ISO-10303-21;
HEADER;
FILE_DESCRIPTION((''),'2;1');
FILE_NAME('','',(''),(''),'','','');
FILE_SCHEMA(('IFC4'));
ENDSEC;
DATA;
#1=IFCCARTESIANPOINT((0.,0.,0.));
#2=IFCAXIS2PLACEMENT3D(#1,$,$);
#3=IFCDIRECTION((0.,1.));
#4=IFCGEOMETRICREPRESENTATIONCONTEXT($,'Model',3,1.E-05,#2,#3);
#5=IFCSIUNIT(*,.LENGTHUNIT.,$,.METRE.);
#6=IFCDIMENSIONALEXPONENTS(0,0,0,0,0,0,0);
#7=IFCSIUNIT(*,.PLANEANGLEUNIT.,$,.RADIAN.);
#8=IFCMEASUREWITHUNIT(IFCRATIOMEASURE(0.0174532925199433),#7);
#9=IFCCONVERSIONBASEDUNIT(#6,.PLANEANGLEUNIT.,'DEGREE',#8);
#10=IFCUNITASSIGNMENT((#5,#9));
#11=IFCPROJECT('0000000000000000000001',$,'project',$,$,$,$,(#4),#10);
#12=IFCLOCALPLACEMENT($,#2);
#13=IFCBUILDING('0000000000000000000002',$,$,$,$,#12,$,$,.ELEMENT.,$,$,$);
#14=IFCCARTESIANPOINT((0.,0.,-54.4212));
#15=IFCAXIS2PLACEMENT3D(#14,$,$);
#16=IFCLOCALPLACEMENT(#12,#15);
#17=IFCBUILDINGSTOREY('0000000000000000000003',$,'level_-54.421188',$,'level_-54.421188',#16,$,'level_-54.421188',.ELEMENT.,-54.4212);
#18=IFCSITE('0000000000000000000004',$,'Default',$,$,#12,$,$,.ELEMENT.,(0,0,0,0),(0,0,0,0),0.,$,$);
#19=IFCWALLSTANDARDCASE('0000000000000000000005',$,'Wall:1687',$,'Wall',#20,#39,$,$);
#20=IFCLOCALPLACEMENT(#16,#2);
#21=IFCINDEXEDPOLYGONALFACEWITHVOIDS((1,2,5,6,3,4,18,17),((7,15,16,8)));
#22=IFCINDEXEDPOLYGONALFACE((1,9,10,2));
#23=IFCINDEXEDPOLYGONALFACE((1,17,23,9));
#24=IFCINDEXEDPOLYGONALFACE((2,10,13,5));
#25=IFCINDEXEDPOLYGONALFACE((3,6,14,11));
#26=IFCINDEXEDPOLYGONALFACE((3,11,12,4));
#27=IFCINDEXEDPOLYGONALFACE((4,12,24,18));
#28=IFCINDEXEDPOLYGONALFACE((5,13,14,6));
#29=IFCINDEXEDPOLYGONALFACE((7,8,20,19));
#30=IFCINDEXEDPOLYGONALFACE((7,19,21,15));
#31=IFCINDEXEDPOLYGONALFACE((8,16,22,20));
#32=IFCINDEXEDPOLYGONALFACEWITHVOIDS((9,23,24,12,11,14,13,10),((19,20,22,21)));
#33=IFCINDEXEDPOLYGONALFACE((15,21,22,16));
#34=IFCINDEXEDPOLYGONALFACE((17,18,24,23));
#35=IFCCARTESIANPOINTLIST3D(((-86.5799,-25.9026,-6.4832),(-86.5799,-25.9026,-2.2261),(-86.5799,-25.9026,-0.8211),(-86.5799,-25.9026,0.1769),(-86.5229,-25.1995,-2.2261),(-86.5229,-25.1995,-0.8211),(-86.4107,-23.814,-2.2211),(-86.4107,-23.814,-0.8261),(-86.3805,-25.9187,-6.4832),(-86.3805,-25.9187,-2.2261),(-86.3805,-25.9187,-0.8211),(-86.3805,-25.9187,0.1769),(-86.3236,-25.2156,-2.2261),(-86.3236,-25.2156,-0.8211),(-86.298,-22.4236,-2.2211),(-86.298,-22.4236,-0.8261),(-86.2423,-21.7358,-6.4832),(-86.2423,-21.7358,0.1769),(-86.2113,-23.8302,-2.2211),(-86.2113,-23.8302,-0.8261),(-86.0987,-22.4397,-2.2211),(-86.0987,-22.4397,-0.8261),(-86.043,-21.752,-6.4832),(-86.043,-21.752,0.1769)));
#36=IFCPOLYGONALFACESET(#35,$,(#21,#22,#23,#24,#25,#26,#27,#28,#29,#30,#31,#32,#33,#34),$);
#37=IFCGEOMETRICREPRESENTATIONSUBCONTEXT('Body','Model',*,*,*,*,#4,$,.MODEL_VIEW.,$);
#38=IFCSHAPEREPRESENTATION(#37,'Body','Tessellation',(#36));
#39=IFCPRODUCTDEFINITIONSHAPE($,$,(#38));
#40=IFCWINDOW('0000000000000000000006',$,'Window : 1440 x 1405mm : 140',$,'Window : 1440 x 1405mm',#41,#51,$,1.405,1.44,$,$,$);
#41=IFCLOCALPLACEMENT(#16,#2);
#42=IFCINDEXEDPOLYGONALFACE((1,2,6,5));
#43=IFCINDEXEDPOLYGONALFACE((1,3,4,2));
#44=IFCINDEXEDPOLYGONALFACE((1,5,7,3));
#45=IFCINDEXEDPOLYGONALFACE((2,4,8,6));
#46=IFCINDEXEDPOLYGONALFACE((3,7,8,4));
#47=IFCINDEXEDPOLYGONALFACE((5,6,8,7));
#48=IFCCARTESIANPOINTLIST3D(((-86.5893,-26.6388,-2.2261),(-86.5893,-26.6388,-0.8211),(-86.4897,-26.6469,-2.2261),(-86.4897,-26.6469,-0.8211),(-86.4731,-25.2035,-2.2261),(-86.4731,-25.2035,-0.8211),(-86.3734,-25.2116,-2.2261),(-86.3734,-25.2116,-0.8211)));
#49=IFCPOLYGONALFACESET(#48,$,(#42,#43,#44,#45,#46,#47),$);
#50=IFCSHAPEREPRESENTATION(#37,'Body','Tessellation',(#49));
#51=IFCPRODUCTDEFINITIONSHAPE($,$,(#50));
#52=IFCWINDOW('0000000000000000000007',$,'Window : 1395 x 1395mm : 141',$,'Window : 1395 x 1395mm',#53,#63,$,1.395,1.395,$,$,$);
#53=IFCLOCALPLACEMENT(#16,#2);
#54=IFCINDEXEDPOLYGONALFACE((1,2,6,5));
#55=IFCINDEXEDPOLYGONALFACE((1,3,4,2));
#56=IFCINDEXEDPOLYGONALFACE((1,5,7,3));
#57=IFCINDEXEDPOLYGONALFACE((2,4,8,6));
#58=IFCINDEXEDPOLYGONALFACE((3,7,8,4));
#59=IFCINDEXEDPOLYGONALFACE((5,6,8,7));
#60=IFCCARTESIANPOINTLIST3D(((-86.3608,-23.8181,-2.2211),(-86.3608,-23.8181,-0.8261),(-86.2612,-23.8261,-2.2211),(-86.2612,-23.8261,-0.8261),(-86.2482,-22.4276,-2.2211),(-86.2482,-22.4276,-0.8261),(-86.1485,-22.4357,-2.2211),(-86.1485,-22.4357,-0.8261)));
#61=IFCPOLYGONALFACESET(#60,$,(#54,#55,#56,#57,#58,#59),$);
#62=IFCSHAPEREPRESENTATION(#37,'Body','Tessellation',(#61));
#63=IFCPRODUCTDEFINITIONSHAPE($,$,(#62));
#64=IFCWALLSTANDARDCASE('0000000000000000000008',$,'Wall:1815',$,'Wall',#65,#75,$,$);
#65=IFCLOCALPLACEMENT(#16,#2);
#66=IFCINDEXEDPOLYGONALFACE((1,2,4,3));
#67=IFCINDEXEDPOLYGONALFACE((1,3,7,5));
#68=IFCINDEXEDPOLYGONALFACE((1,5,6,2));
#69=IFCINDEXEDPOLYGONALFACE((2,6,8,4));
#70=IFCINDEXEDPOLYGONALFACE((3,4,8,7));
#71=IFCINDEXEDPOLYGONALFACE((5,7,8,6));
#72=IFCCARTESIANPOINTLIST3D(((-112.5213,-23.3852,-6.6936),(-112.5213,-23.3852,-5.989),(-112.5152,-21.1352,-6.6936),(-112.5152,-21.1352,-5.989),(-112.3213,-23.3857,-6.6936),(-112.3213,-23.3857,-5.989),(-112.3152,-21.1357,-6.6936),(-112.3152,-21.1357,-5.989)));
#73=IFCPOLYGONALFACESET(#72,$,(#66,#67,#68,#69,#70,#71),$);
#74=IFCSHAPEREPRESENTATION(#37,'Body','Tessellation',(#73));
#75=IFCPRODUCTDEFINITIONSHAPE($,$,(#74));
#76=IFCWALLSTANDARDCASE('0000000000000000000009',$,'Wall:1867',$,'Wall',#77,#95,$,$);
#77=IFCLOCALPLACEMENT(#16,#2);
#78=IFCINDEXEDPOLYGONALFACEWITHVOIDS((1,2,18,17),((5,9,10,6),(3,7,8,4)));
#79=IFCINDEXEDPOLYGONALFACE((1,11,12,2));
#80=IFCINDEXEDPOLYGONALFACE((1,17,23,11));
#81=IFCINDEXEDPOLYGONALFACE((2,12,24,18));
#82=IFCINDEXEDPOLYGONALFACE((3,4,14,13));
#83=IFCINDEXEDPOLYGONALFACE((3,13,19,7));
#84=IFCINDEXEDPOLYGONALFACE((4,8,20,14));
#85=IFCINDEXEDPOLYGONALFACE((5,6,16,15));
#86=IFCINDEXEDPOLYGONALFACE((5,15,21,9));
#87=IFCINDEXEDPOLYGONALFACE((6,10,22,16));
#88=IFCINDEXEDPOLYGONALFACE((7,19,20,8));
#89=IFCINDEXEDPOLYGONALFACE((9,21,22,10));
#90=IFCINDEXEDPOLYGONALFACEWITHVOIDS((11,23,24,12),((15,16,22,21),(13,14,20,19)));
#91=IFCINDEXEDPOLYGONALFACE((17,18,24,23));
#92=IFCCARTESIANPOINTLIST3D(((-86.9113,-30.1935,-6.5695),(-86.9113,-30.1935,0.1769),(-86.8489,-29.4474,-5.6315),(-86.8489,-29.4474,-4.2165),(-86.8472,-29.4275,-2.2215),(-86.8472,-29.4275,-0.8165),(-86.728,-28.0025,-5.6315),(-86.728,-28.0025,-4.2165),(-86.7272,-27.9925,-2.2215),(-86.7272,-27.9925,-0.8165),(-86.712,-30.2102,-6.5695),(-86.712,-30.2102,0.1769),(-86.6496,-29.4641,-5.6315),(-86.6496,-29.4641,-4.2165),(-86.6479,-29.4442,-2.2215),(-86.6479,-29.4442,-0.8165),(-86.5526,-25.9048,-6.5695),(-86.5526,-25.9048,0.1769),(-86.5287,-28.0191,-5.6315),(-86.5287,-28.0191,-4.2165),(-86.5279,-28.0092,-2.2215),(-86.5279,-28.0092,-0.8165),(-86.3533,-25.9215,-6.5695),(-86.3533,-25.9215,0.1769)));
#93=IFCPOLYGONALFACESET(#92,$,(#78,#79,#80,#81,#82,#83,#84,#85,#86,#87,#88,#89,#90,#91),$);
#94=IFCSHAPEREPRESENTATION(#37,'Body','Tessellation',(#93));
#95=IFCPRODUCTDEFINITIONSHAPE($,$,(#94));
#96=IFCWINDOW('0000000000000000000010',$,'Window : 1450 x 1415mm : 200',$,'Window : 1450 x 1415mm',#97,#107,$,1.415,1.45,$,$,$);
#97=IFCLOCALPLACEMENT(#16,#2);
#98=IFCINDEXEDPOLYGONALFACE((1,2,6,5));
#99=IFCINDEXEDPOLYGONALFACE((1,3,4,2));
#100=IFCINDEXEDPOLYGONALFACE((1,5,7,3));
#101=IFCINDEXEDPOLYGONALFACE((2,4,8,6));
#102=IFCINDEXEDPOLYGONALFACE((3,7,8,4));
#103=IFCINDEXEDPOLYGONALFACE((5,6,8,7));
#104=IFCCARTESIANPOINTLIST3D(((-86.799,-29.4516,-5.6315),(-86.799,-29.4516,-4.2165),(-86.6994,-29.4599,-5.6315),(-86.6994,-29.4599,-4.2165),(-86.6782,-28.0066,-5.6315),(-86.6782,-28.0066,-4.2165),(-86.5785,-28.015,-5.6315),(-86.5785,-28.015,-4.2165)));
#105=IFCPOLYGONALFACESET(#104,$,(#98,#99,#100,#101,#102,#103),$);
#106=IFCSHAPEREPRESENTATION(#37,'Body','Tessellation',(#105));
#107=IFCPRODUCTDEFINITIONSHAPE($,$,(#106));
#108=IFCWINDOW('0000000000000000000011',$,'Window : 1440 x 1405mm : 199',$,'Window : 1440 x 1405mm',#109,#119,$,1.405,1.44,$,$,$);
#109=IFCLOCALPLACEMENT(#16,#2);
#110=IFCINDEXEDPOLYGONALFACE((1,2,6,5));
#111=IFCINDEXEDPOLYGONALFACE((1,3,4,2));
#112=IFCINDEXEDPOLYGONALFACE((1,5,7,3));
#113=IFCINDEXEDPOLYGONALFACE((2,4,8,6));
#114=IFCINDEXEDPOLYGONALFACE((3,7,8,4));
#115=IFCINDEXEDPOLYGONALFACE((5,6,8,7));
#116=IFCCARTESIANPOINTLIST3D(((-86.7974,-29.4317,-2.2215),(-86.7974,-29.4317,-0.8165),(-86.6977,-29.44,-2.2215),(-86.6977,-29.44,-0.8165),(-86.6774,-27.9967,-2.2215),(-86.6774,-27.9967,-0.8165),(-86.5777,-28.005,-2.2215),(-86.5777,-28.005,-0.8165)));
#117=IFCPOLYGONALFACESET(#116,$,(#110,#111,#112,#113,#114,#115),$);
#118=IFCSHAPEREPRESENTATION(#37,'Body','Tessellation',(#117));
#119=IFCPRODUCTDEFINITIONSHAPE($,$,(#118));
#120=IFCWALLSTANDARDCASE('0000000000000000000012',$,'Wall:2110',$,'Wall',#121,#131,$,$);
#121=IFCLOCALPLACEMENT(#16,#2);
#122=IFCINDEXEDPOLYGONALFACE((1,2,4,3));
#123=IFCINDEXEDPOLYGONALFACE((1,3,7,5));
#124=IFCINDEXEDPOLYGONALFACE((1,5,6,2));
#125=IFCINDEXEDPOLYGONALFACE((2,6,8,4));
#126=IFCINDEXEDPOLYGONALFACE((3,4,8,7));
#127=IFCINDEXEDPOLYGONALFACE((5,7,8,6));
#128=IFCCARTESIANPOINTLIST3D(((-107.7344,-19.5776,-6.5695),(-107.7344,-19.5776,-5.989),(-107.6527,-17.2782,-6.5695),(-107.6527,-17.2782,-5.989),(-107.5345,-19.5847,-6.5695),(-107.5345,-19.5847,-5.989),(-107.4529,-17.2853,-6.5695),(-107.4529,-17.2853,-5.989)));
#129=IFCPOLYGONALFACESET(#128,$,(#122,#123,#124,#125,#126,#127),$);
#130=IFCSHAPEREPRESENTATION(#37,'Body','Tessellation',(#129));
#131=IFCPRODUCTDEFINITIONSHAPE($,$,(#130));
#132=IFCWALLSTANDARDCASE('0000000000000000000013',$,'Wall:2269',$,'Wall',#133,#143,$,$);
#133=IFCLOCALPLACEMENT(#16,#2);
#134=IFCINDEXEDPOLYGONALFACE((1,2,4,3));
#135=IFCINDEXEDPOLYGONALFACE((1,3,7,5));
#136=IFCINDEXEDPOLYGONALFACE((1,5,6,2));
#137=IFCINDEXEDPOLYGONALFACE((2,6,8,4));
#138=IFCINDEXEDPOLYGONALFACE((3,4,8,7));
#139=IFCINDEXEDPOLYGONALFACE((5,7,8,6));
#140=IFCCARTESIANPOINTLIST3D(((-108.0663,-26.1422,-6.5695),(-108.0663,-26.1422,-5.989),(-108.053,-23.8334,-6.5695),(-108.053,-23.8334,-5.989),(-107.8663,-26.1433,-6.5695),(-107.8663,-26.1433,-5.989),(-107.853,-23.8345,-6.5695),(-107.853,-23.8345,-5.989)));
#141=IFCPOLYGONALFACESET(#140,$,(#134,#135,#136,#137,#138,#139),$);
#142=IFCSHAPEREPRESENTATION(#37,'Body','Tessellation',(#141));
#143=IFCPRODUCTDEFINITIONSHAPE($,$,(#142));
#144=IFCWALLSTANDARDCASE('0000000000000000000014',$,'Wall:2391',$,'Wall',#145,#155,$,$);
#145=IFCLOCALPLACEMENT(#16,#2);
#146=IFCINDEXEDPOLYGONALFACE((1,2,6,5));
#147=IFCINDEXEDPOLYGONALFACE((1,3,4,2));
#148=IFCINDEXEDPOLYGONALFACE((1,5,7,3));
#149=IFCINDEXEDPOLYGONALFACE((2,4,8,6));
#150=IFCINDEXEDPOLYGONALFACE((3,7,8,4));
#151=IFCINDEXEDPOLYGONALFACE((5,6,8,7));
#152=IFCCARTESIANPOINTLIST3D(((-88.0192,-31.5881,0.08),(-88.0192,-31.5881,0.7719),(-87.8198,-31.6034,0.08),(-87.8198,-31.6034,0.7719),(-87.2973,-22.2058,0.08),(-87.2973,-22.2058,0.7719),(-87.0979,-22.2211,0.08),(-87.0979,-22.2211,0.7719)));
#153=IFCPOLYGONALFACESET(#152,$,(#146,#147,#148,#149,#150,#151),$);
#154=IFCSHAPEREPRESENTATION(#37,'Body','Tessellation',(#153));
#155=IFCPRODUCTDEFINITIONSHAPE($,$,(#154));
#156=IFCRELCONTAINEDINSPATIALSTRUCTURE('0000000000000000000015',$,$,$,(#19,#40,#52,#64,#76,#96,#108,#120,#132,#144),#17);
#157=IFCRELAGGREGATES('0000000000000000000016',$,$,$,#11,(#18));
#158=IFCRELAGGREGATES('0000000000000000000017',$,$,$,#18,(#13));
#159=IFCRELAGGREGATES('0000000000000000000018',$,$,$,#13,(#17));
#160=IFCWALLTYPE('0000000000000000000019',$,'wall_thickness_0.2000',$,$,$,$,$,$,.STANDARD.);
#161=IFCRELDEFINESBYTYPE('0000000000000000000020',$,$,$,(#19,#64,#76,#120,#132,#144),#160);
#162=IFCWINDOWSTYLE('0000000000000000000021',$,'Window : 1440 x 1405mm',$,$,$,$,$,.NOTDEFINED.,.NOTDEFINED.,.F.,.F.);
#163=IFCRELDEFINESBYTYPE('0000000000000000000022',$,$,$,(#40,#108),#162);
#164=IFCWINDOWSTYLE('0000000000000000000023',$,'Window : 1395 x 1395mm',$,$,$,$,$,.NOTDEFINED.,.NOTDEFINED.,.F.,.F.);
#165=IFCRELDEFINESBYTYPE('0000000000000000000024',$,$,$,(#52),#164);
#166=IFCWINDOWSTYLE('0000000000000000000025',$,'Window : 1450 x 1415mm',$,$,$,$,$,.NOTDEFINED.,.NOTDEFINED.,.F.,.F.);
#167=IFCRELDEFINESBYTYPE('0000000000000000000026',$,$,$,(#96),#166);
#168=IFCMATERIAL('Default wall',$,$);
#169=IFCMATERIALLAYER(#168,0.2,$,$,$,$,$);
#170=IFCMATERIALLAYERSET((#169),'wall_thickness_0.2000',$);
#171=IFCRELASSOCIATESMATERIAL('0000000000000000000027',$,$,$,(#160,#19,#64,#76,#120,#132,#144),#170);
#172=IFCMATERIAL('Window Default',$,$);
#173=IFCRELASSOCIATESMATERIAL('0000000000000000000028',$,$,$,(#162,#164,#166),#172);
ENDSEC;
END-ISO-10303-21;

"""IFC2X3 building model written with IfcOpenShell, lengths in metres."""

from ifc_helpers import new_model, entity, si_unit, converted_unit, direction, frame, frame_2d, origin, origin_2d_with_axis, place, context, subcontext, project, spatial, polyline, rectangle, outline, extrude, source, transform, mapped, material, layer, layer_set, layer_usage, type_object, type_shapes, element, fill, save


model = new_model("IFC2X3")

# Units and contexts
model_context = context("Model", 3, precision=1e-05, world=origin(), true_north=direction((0.0, 1.0)))
body_context = subcontext(model_context, "Body", "Model", "MODEL_VIEW")
ifc_project = project(units=[si_unit("LENGTHUNIT", "METRE"), converted_unit("PLANEANGLEUNIT", "DEGREE", entity("IfcRatioMeasure", 0.0174532925199433), si_unit("PLANEANGLEUNIT", "RADIAN"), dimensions=[0, 0, 0, 0, 0, 0, 0])], contexts=[model_context])

# Site, building, storey
placement_1 = place(None, origin())
site = spatial("IfcSite", under=ifc_project, at=placement_1, Name="Default", CompositionType="ELEMENT", RefLatitude=(0, 0, 0, 0), RefLongitude=(0, 0, 0, 0), RefElevation=0.0)
building = spatial("IfcBuilding", under=site, at=placement_1, CompositionType="ELEMENT")
storey_placement = place(placement_1, frame((0.0, 0.0, -54.4212)))
storey = spatial("IfcBuildingStorey", under=building, at=storey_placement, Name="level_-54.421188", ObjectType="level_-54.421188", LongName="level_-54.421188", CompositionType="ELEMENT", Elevation=-54.4212)

# Shared definitions
ifc_material_1 = material(Name="Default wall")
ifc_layer = layer(ifc_material_1, 0.2)
ifc_layer_set = layer_set([ifc_layer], Name="wall_thickness_0.2000")
ifc_layer_usage = layer_usage(ifc_layer_set, "AXIS2", "POSITIVE", -0.1)
wall_type = type_object("IfcWallType", Name="wall_thickness_0.2000", PredefinedType="STANDARD", material=ifc_layer_set)
ifc_material_2 = material(Name="Window Default")

# Wall, openings, windows
placement_2 = place(placement_1, frame((0.0, 0.0, -60.9044)))
wall_1_placement = place(placement_2, frame((-86.1426, -21.7439, 0.0), z_axis=(0.0, 0.0, 1.0), x_axis=(-0.080745, -0.996735, 0.0)))
wall_1 = element("IfcWallStandardCase", 1, at=wall_1_placement, inside=storey, type_object=wall_type, material=ifc_layer_usage, Name="Wall:1687", ObjectType="Wall", context=body_context, shape_type="SweptSolid", body=[
    extrude(outline(polyline([(4.1804, -0.1), (4.1804, 0.1), (0.0, 0.1), (0.0, -0.1), (4.1804, -0.1)])), origin(), (0.0, 0.0, 1.0), 6.6601),
])
opening_1_placement = place(wall_1_placement, frame((3.475, -0.1, 4.2571)))
opening_1 = element("IfcOpeningElement", 2, at=opening_1_placement, cuts=wall_1, ObjectType="Opening", context=body_context, shape_type="SweptSolid", body=[
    extrude(rectangle(XDim=1.44, YDim=1.405, at=frame_2d((0.7025, 0.72), x_axis=(0.0, 1.0))), frame((0.0, 0.0, 0.0), z_axis=(0.0, 1.0, 0.0), x_axis=(0.0, 0.0, 1.0)), (0.0, 0.0, 1.0), 0.2),
])
opening_2_placement = place(wall_1_placement, frame((0.69, -0.1, 4.2621)))
opening_2 = element("IfcOpeningElement", 3, at=opening_2_placement, cuts=wall_1, ObjectType="Opening", context=body_context, shape_type="SweptSolid", body=[
    extrude(rectangle(XDim=1.395, YDim=1.395, at=frame_2d((0.6975, 0.6975), x_axis=(0.0, 1.0))), frame((0.0, 0.0, 0.0), z_axis=(0.0, 1.0, 0.0), x_axis=(0.0, 0.0, 1.0)), (0.0, 0.0, 1.0), 0.2),
])
window_style_1 = type_object("IfcWindowStyle", Name="Window : 1440 x 1405mm", ConstructionType="NOTDEFINED", OperationType="NOTDEFINED", ParameterTakesPrecedence=False, Sizeable=False, material=ifc_material_2)
shared_shape_1 = source(origin(), body_context, "Body", "SweptSolid", [
    extrude(rectangle(XDim=0.1, YDim=1.44, at=origin_2d_with_axis()), frame((0.72, 0.1, 0.0), z_axis=(0.0, 0.0, 1.0), x_axis=(0.0, 1.0, 0.0)), (0.0, 0.0, 1.0), 1.405),
])
type_shapes(window_style_1, [shared_shape_1])
window_1_placement = place(opening_1_placement, origin())
window_1 = element("IfcWindow", 4, at=window_1_placement, inside=storey, type_object=window_style_1, Name="Window : 1440 x 1405mm : 140", ObjectType="Window : 1440 x 1405mm", OverallHeight=1.405, OverallWidth=1.44, context=body_context, shape_type="MappedRepresentation", body=[
    mapped(shared_shape_1, transform((0.0, 0.0, 0.0), scale=1.0)),
])
fill(opening_1, window_1)
window_style_2 = type_object("IfcWindowStyle", Name="Window : 1395 x 1395mm", ConstructionType="NOTDEFINED", OperationType="NOTDEFINED", ParameterTakesPrecedence=False, Sizeable=False, material=ifc_material_2)
shared_shape_2 = source(origin(), body_context, "Body", "SweptSolid", [
    extrude(rectangle(XDim=0.1, YDim=1.395, at=origin_2d_with_axis()), frame((0.6975, 0.1, 0.0), z_axis=(0.0, 0.0, 1.0), x_axis=(0.0, 1.0, 0.0)), (0.0, 0.0, 1.0), 1.395),
])
type_shapes(window_style_2, [shared_shape_2])
window_2_placement = place(opening_2_placement, origin())
window_2 = element("IfcWindow", 5, at=window_2_placement, inside=storey, type_object=window_style_2, Name="Window : 1395 x 1395mm : 141", ObjectType="Window : 1395 x 1395mm", OverallHeight=1.395, OverallWidth=1.395, context=body_context, shape_type="MappedRepresentation", body=[
    mapped(shared_shape_2, transform((0.0, 0.0, 0.0), scale=1.0)),
])
fill(opening_2, window_2)

# Wall
placement_3 = place(placement_1, frame((0.0, 0.0, -61.1148)))
wall_2_placement = place(placement_3, frame((-112.4152, -21.1355, 0.0), z_axis=(0.0, 0.0, 1.0), x_axis=(-0.002692, -0.999996, 0.0)))
element("IfcWallStandardCase", 6, at=wall_2_placement, inside=storey, type_object=wall_type, material=ifc_layer_usage, Name="Wall:1815", ObjectType="Wall", context=body_context, shape_type="SweptSolid", body=[
    extrude(outline(polyline([(2.25, -0.1), (2.25, 0.1), (0.0, 0.1), (0.0, -0.1), (2.25, -0.1)])), origin(), (0.0, 0.0, 1.0), 0.7046),
])

# Wall, openings, windows
placement_4 = place(placement_1, frame((0.0, 0.0, -60.9907)))
wall_3_placement = place(placement_4, frame((-86.453, -25.9131, 0.0), z_axis=(0.0, 0.0, 1.0), x_axis=(-0.083335, -0.996522, 0.0)))
wall_3 = element("IfcWallStandardCase", 7, at=wall_3_placement, inside=storey, type_object=wall_type, material=ifc_layer_usage, Name="Wall:1867", ObjectType="Wall", context=body_context, shape_type="SweptSolid", body=[
    extrude(outline(polyline([(4.3037, -0.1), (4.3037, 0.1), (0.0, 0.1), (0.0, -0.1), (4.3037, -0.1)])), origin(), (0.0, 0.0, 1.0), 6.7464),
])
opening_3_placement = place(wall_3_placement, frame((2.095, -0.1, 4.3479)))
opening_3 = element("IfcOpeningElement", 8, at=opening_3_placement, cuts=wall_3, ObjectType="Opening", context=body_context, shape_type="SweptSolid", body=[
    extrude(rectangle(XDim=1.44, YDim=1.405, at=frame_2d((0.7025, 0.72), x_axis=(0.0, 1.0))), frame((0.0, 0.0, 0.0), z_axis=(0.0, 1.0, 0.0), x_axis=(0.0, 0.0, 1.0)), (0.0, 0.0, 1.0), 0.2),
])
opening_4_placement = place(wall_3_placement, frame((2.105, -0.1, 0.9379)))
opening_4 = element("IfcOpeningElement", 9, at=opening_4_placement, cuts=wall_3, ObjectType="Opening", context=body_context, shape_type="SweptSolid", body=[
    extrude(rectangle(XDim=1.45, YDim=1.415, at=frame_2d((0.7075, 0.725), x_axis=(0.0, 1.0))), frame((0.0, 0.0, 0.0), z_axis=(0.0, 1.0, 0.0), x_axis=(0.0, 0.0, 1.0)), (0.0, 0.0, 1.0), 0.2),
])
window_style_3 = type_object("IfcWindowStyle", Name="Window : 1450 x 1415mm", ConstructionType="NOTDEFINED", OperationType="NOTDEFINED", ParameterTakesPrecedence=False, Sizeable=False, material=ifc_material_2)
shared_shape_3 = source(origin(), body_context, "Body", "SweptSolid", [
    extrude(rectangle(XDim=0.1, YDim=1.45, at=origin_2d_with_axis()), frame((0.725, 0.1, 0.0), z_axis=(0.0, 0.0, 1.0), x_axis=(0.0, 1.0, 0.0)), (0.0, 0.0, 1.0), 1.415),
])
type_shapes(window_style_3, [shared_shape_3])
window_3_placement = place(opening_4_placement, origin())
window_3 = element("IfcWindow", 10, at=window_3_placement, inside=storey, type_object=window_style_3, Name="Window : 1450 x 1415mm : 200", ObjectType="Window : 1450 x 1415mm", OverallHeight=1.415, OverallWidth=1.45, context=body_context, shape_type="MappedRepresentation", body=[
    mapped(shared_shape_3, transform((0.0, 0.0, 0.0), scale=1.0)),
])
fill(opening_4, window_3)
window_4_placement = place(opening_3_placement, origin())
window_4 = element("IfcWindow", 11, at=window_4_placement, inside=storey, type_object=window_style_1, Name="Window : 1440 x 1405mm : 199", ObjectType="Window : 1440 x 1405mm", OverallHeight=1.405, OverallWidth=1.44, context=body_context, shape_type="MappedRepresentation", body=[
    mapped(shared_shape_1, transform((0.0, 0.0, 0.0), scale=1.0)),
])
fill(opening_3, window_4)

# Walls
placement_5 = place(placement_1, frame((0.0, 0.0, -60.9907)))
wall_4_placement = place(placement_5, frame((-107.6344, -19.5812, 0.0), z_axis=(0.0, 0.0, 1.0), x_axis=(0.035486, 0.99937, 0.0)))
element("IfcWallStandardCase", 12, at=wall_4_placement, inside=storey, type_object=wall_type, material=ifc_layer_usage, Name="Wall:2110", ObjectType="Wall", context=body_context, shape_type="SweptSolid", body=[
    extrude(outline(polyline([(2.3009, -0.1), (2.3009, 0.1), (0.0, 0.1), (0.0, -0.1), (2.3009, -0.1)])), origin(), (0.0, 0.0, 1.0), 0.5805),
])
placement_6 = place(placement_1, frame((0.0, 0.0, -60.9907)))
wall_5_placement = place(placement_6, frame((-107.9663, -26.1428, 0.0), z_axis=(0.0, 0.0, 1.0), x_axis=(0.005746, 0.999983, 0.0)))
element("IfcWallStandardCase", 13, at=wall_5_placement, inside=storey, type_object=wall_type, material=ifc_layer_usage, Name="Wall:2269", ObjectType="Wall", context=body_context, shape_type="SweptSolid", body=[
    extrude(outline(polyline([(2.3089, -0.1), (2.3089, 0.1), (0.0, 0.1), (0.0, -0.1), (2.3089, -0.1)])), origin(), (0.0, 0.0, 1.0), 0.5805),
])
placement_7 = place(placement_1, frame((0.0, 0.0, -54.3412)))
wall_6_placement = place(placement_7, frame((-87.9195, -31.5957, 0.0), z_axis=(0.0, 0.0, 1.0), x_axis=(0.076725, 0.997052, 0.0)))
element("IfcWallStandardCase", 14, at=wall_6_placement, inside=storey, type_object=wall_type, material=ifc_layer_usage, Name="Wall:2391", ObjectType="Wall", context=body_context, shape_type="SweptSolid", body=[
    extrude(outline(polyline([(9.41, -0.1), (9.41, 0.1), (0.0, 0.1), (0.0, -0.1), (9.41, -0.1)])), origin(), (0.0, 0.0, 1.0), 0.692),
])

save(model, "model.ifc")
